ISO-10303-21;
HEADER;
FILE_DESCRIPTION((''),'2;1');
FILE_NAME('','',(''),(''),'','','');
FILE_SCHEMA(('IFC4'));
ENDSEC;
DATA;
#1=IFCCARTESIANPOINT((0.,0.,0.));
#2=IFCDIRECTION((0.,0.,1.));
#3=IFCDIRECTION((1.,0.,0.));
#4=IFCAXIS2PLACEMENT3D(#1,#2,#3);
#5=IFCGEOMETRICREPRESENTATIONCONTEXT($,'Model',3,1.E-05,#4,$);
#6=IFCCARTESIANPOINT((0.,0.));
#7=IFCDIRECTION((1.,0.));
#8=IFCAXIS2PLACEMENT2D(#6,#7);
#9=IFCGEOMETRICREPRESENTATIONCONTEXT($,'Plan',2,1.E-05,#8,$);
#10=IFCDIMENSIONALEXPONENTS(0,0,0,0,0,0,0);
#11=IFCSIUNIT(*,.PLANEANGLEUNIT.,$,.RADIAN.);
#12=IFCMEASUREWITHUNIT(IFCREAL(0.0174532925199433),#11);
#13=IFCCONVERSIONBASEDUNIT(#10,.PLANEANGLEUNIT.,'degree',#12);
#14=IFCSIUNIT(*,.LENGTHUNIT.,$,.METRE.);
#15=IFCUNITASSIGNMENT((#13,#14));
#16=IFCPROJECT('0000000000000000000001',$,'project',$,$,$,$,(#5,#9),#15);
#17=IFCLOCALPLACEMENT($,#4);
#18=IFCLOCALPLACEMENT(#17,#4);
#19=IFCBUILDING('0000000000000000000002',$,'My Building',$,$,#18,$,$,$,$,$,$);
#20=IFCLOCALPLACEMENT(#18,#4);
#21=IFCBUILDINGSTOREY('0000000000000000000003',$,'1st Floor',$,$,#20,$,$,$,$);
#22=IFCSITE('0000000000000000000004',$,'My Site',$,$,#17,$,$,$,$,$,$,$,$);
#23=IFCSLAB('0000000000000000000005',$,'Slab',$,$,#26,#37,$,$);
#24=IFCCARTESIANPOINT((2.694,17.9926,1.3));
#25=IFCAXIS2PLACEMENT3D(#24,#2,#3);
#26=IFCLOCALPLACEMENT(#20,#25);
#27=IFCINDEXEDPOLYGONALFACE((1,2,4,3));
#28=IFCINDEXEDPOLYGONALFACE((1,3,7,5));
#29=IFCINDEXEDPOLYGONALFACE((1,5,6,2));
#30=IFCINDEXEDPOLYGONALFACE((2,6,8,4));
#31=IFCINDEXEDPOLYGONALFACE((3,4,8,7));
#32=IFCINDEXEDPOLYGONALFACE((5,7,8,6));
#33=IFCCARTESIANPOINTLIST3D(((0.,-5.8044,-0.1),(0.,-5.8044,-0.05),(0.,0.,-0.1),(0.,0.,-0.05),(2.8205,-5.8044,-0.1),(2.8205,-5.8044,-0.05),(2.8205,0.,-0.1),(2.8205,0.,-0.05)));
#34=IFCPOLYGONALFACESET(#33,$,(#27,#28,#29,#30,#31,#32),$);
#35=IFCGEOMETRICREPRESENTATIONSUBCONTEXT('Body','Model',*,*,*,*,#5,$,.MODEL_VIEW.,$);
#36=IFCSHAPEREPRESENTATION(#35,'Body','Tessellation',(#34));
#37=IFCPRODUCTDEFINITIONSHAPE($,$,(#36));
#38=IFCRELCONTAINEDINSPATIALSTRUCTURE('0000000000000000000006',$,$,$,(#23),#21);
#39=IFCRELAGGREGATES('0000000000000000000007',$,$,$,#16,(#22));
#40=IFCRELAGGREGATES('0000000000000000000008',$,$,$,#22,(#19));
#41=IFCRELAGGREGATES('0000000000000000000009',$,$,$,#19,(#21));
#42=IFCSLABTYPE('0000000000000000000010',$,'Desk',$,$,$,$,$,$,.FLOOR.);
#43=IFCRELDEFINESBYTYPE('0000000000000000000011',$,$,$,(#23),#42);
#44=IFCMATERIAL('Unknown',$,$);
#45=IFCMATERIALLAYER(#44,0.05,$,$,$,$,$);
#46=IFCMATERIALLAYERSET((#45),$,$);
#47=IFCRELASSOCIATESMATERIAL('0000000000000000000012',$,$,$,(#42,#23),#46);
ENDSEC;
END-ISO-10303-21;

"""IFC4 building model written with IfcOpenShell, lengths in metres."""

from ifc_helpers import new_model, entity, si_unit, converted_unit, frame, origin_with_axes, origin_2d_with_axis, place, context, subcontext, project, spatial, indexed_curve, outline, extrude, material, layer, layer_set, layer_usage, type_object, element, save


model = new_model("IFC4")

# Units and contexts
model_context = context("Model", 3, precision=1e-05, world=origin_with_axes())
plan_context = context("Plan", 2, precision=1e-05, world=origin_2d_with_axis())
body_context_1 = subcontext(model_context, "Body", "Model", "MODEL_VIEW")
ifc_project = project(units=[converted_unit("PLANEANGLEUNIT", "degree", entity("IfcReal", 0.0174532925199433), si_unit("PLANEANGLEUNIT", "RADIAN"), dimensions=[0, 0, 0, 0, 0, 0, 0]), si_unit("LENGTHUNIT", "METRE")], contexts=[model_context, plan_context])

# Site, building, storey
site_placement = place(None, origin_with_axes())
site = spatial("IfcSite", under=ifc_project, at=site_placement, Name="My Site")
building_placement = place(site_placement, origin_with_axes())
building = spatial("IfcBuilding", under=site, at=building_placement, Name="My Building")
storey_placement = place(building_placement, origin_with_axes())
storey = spatial("IfcBuildingStorey", under=building, at=storey_placement, Name="1st Floor")

# Shared definitions
ifc_material = material(Name="Unknown")

# Slab
ifc_layer_1 = layer(ifc_material, 0.05)
ifc_layer_set_1 = layer_set([ifc_layer_1])
ifc_layer_usage_1 = layer_usage(ifc_layer_set_1, "AXIS3", "POSITIVE", -0.1)
slab_type_1 = type_object("IfcSlabType", Name="Desk", PredefinedType="FLOOR", material=ifc_layer_set_1)
slab_1_placement = place(storey_placement, frame((2.694, 17.9926, 1.3), z_axis=(0.0, 0.0, 1.0), x_axis=(1.0, 0.0, 0.0)))
element("IfcSlab", 1, at=slab_1_placement, inside=storey, type_object=slab_type_1, material=ifc_layer_usage_1, Name="Slab", context=body_context_1, shape_type="SweptSolid", body=[
    extrude(outline(indexed_curve([(0.0, 0.0), (2.8205, 0.0), (2.8205, -5.8044), (0.0, -5.8044), (0.0, 0.0)])), frame((0.0, 0.0, -0.1), z_axis=(0.0, 0.0, 1.0), x_axis=(1.0, 0.0, 0.0)), (0.0, 0.0, 1.0), 0.05),
])

save(model, "model.ifc")
